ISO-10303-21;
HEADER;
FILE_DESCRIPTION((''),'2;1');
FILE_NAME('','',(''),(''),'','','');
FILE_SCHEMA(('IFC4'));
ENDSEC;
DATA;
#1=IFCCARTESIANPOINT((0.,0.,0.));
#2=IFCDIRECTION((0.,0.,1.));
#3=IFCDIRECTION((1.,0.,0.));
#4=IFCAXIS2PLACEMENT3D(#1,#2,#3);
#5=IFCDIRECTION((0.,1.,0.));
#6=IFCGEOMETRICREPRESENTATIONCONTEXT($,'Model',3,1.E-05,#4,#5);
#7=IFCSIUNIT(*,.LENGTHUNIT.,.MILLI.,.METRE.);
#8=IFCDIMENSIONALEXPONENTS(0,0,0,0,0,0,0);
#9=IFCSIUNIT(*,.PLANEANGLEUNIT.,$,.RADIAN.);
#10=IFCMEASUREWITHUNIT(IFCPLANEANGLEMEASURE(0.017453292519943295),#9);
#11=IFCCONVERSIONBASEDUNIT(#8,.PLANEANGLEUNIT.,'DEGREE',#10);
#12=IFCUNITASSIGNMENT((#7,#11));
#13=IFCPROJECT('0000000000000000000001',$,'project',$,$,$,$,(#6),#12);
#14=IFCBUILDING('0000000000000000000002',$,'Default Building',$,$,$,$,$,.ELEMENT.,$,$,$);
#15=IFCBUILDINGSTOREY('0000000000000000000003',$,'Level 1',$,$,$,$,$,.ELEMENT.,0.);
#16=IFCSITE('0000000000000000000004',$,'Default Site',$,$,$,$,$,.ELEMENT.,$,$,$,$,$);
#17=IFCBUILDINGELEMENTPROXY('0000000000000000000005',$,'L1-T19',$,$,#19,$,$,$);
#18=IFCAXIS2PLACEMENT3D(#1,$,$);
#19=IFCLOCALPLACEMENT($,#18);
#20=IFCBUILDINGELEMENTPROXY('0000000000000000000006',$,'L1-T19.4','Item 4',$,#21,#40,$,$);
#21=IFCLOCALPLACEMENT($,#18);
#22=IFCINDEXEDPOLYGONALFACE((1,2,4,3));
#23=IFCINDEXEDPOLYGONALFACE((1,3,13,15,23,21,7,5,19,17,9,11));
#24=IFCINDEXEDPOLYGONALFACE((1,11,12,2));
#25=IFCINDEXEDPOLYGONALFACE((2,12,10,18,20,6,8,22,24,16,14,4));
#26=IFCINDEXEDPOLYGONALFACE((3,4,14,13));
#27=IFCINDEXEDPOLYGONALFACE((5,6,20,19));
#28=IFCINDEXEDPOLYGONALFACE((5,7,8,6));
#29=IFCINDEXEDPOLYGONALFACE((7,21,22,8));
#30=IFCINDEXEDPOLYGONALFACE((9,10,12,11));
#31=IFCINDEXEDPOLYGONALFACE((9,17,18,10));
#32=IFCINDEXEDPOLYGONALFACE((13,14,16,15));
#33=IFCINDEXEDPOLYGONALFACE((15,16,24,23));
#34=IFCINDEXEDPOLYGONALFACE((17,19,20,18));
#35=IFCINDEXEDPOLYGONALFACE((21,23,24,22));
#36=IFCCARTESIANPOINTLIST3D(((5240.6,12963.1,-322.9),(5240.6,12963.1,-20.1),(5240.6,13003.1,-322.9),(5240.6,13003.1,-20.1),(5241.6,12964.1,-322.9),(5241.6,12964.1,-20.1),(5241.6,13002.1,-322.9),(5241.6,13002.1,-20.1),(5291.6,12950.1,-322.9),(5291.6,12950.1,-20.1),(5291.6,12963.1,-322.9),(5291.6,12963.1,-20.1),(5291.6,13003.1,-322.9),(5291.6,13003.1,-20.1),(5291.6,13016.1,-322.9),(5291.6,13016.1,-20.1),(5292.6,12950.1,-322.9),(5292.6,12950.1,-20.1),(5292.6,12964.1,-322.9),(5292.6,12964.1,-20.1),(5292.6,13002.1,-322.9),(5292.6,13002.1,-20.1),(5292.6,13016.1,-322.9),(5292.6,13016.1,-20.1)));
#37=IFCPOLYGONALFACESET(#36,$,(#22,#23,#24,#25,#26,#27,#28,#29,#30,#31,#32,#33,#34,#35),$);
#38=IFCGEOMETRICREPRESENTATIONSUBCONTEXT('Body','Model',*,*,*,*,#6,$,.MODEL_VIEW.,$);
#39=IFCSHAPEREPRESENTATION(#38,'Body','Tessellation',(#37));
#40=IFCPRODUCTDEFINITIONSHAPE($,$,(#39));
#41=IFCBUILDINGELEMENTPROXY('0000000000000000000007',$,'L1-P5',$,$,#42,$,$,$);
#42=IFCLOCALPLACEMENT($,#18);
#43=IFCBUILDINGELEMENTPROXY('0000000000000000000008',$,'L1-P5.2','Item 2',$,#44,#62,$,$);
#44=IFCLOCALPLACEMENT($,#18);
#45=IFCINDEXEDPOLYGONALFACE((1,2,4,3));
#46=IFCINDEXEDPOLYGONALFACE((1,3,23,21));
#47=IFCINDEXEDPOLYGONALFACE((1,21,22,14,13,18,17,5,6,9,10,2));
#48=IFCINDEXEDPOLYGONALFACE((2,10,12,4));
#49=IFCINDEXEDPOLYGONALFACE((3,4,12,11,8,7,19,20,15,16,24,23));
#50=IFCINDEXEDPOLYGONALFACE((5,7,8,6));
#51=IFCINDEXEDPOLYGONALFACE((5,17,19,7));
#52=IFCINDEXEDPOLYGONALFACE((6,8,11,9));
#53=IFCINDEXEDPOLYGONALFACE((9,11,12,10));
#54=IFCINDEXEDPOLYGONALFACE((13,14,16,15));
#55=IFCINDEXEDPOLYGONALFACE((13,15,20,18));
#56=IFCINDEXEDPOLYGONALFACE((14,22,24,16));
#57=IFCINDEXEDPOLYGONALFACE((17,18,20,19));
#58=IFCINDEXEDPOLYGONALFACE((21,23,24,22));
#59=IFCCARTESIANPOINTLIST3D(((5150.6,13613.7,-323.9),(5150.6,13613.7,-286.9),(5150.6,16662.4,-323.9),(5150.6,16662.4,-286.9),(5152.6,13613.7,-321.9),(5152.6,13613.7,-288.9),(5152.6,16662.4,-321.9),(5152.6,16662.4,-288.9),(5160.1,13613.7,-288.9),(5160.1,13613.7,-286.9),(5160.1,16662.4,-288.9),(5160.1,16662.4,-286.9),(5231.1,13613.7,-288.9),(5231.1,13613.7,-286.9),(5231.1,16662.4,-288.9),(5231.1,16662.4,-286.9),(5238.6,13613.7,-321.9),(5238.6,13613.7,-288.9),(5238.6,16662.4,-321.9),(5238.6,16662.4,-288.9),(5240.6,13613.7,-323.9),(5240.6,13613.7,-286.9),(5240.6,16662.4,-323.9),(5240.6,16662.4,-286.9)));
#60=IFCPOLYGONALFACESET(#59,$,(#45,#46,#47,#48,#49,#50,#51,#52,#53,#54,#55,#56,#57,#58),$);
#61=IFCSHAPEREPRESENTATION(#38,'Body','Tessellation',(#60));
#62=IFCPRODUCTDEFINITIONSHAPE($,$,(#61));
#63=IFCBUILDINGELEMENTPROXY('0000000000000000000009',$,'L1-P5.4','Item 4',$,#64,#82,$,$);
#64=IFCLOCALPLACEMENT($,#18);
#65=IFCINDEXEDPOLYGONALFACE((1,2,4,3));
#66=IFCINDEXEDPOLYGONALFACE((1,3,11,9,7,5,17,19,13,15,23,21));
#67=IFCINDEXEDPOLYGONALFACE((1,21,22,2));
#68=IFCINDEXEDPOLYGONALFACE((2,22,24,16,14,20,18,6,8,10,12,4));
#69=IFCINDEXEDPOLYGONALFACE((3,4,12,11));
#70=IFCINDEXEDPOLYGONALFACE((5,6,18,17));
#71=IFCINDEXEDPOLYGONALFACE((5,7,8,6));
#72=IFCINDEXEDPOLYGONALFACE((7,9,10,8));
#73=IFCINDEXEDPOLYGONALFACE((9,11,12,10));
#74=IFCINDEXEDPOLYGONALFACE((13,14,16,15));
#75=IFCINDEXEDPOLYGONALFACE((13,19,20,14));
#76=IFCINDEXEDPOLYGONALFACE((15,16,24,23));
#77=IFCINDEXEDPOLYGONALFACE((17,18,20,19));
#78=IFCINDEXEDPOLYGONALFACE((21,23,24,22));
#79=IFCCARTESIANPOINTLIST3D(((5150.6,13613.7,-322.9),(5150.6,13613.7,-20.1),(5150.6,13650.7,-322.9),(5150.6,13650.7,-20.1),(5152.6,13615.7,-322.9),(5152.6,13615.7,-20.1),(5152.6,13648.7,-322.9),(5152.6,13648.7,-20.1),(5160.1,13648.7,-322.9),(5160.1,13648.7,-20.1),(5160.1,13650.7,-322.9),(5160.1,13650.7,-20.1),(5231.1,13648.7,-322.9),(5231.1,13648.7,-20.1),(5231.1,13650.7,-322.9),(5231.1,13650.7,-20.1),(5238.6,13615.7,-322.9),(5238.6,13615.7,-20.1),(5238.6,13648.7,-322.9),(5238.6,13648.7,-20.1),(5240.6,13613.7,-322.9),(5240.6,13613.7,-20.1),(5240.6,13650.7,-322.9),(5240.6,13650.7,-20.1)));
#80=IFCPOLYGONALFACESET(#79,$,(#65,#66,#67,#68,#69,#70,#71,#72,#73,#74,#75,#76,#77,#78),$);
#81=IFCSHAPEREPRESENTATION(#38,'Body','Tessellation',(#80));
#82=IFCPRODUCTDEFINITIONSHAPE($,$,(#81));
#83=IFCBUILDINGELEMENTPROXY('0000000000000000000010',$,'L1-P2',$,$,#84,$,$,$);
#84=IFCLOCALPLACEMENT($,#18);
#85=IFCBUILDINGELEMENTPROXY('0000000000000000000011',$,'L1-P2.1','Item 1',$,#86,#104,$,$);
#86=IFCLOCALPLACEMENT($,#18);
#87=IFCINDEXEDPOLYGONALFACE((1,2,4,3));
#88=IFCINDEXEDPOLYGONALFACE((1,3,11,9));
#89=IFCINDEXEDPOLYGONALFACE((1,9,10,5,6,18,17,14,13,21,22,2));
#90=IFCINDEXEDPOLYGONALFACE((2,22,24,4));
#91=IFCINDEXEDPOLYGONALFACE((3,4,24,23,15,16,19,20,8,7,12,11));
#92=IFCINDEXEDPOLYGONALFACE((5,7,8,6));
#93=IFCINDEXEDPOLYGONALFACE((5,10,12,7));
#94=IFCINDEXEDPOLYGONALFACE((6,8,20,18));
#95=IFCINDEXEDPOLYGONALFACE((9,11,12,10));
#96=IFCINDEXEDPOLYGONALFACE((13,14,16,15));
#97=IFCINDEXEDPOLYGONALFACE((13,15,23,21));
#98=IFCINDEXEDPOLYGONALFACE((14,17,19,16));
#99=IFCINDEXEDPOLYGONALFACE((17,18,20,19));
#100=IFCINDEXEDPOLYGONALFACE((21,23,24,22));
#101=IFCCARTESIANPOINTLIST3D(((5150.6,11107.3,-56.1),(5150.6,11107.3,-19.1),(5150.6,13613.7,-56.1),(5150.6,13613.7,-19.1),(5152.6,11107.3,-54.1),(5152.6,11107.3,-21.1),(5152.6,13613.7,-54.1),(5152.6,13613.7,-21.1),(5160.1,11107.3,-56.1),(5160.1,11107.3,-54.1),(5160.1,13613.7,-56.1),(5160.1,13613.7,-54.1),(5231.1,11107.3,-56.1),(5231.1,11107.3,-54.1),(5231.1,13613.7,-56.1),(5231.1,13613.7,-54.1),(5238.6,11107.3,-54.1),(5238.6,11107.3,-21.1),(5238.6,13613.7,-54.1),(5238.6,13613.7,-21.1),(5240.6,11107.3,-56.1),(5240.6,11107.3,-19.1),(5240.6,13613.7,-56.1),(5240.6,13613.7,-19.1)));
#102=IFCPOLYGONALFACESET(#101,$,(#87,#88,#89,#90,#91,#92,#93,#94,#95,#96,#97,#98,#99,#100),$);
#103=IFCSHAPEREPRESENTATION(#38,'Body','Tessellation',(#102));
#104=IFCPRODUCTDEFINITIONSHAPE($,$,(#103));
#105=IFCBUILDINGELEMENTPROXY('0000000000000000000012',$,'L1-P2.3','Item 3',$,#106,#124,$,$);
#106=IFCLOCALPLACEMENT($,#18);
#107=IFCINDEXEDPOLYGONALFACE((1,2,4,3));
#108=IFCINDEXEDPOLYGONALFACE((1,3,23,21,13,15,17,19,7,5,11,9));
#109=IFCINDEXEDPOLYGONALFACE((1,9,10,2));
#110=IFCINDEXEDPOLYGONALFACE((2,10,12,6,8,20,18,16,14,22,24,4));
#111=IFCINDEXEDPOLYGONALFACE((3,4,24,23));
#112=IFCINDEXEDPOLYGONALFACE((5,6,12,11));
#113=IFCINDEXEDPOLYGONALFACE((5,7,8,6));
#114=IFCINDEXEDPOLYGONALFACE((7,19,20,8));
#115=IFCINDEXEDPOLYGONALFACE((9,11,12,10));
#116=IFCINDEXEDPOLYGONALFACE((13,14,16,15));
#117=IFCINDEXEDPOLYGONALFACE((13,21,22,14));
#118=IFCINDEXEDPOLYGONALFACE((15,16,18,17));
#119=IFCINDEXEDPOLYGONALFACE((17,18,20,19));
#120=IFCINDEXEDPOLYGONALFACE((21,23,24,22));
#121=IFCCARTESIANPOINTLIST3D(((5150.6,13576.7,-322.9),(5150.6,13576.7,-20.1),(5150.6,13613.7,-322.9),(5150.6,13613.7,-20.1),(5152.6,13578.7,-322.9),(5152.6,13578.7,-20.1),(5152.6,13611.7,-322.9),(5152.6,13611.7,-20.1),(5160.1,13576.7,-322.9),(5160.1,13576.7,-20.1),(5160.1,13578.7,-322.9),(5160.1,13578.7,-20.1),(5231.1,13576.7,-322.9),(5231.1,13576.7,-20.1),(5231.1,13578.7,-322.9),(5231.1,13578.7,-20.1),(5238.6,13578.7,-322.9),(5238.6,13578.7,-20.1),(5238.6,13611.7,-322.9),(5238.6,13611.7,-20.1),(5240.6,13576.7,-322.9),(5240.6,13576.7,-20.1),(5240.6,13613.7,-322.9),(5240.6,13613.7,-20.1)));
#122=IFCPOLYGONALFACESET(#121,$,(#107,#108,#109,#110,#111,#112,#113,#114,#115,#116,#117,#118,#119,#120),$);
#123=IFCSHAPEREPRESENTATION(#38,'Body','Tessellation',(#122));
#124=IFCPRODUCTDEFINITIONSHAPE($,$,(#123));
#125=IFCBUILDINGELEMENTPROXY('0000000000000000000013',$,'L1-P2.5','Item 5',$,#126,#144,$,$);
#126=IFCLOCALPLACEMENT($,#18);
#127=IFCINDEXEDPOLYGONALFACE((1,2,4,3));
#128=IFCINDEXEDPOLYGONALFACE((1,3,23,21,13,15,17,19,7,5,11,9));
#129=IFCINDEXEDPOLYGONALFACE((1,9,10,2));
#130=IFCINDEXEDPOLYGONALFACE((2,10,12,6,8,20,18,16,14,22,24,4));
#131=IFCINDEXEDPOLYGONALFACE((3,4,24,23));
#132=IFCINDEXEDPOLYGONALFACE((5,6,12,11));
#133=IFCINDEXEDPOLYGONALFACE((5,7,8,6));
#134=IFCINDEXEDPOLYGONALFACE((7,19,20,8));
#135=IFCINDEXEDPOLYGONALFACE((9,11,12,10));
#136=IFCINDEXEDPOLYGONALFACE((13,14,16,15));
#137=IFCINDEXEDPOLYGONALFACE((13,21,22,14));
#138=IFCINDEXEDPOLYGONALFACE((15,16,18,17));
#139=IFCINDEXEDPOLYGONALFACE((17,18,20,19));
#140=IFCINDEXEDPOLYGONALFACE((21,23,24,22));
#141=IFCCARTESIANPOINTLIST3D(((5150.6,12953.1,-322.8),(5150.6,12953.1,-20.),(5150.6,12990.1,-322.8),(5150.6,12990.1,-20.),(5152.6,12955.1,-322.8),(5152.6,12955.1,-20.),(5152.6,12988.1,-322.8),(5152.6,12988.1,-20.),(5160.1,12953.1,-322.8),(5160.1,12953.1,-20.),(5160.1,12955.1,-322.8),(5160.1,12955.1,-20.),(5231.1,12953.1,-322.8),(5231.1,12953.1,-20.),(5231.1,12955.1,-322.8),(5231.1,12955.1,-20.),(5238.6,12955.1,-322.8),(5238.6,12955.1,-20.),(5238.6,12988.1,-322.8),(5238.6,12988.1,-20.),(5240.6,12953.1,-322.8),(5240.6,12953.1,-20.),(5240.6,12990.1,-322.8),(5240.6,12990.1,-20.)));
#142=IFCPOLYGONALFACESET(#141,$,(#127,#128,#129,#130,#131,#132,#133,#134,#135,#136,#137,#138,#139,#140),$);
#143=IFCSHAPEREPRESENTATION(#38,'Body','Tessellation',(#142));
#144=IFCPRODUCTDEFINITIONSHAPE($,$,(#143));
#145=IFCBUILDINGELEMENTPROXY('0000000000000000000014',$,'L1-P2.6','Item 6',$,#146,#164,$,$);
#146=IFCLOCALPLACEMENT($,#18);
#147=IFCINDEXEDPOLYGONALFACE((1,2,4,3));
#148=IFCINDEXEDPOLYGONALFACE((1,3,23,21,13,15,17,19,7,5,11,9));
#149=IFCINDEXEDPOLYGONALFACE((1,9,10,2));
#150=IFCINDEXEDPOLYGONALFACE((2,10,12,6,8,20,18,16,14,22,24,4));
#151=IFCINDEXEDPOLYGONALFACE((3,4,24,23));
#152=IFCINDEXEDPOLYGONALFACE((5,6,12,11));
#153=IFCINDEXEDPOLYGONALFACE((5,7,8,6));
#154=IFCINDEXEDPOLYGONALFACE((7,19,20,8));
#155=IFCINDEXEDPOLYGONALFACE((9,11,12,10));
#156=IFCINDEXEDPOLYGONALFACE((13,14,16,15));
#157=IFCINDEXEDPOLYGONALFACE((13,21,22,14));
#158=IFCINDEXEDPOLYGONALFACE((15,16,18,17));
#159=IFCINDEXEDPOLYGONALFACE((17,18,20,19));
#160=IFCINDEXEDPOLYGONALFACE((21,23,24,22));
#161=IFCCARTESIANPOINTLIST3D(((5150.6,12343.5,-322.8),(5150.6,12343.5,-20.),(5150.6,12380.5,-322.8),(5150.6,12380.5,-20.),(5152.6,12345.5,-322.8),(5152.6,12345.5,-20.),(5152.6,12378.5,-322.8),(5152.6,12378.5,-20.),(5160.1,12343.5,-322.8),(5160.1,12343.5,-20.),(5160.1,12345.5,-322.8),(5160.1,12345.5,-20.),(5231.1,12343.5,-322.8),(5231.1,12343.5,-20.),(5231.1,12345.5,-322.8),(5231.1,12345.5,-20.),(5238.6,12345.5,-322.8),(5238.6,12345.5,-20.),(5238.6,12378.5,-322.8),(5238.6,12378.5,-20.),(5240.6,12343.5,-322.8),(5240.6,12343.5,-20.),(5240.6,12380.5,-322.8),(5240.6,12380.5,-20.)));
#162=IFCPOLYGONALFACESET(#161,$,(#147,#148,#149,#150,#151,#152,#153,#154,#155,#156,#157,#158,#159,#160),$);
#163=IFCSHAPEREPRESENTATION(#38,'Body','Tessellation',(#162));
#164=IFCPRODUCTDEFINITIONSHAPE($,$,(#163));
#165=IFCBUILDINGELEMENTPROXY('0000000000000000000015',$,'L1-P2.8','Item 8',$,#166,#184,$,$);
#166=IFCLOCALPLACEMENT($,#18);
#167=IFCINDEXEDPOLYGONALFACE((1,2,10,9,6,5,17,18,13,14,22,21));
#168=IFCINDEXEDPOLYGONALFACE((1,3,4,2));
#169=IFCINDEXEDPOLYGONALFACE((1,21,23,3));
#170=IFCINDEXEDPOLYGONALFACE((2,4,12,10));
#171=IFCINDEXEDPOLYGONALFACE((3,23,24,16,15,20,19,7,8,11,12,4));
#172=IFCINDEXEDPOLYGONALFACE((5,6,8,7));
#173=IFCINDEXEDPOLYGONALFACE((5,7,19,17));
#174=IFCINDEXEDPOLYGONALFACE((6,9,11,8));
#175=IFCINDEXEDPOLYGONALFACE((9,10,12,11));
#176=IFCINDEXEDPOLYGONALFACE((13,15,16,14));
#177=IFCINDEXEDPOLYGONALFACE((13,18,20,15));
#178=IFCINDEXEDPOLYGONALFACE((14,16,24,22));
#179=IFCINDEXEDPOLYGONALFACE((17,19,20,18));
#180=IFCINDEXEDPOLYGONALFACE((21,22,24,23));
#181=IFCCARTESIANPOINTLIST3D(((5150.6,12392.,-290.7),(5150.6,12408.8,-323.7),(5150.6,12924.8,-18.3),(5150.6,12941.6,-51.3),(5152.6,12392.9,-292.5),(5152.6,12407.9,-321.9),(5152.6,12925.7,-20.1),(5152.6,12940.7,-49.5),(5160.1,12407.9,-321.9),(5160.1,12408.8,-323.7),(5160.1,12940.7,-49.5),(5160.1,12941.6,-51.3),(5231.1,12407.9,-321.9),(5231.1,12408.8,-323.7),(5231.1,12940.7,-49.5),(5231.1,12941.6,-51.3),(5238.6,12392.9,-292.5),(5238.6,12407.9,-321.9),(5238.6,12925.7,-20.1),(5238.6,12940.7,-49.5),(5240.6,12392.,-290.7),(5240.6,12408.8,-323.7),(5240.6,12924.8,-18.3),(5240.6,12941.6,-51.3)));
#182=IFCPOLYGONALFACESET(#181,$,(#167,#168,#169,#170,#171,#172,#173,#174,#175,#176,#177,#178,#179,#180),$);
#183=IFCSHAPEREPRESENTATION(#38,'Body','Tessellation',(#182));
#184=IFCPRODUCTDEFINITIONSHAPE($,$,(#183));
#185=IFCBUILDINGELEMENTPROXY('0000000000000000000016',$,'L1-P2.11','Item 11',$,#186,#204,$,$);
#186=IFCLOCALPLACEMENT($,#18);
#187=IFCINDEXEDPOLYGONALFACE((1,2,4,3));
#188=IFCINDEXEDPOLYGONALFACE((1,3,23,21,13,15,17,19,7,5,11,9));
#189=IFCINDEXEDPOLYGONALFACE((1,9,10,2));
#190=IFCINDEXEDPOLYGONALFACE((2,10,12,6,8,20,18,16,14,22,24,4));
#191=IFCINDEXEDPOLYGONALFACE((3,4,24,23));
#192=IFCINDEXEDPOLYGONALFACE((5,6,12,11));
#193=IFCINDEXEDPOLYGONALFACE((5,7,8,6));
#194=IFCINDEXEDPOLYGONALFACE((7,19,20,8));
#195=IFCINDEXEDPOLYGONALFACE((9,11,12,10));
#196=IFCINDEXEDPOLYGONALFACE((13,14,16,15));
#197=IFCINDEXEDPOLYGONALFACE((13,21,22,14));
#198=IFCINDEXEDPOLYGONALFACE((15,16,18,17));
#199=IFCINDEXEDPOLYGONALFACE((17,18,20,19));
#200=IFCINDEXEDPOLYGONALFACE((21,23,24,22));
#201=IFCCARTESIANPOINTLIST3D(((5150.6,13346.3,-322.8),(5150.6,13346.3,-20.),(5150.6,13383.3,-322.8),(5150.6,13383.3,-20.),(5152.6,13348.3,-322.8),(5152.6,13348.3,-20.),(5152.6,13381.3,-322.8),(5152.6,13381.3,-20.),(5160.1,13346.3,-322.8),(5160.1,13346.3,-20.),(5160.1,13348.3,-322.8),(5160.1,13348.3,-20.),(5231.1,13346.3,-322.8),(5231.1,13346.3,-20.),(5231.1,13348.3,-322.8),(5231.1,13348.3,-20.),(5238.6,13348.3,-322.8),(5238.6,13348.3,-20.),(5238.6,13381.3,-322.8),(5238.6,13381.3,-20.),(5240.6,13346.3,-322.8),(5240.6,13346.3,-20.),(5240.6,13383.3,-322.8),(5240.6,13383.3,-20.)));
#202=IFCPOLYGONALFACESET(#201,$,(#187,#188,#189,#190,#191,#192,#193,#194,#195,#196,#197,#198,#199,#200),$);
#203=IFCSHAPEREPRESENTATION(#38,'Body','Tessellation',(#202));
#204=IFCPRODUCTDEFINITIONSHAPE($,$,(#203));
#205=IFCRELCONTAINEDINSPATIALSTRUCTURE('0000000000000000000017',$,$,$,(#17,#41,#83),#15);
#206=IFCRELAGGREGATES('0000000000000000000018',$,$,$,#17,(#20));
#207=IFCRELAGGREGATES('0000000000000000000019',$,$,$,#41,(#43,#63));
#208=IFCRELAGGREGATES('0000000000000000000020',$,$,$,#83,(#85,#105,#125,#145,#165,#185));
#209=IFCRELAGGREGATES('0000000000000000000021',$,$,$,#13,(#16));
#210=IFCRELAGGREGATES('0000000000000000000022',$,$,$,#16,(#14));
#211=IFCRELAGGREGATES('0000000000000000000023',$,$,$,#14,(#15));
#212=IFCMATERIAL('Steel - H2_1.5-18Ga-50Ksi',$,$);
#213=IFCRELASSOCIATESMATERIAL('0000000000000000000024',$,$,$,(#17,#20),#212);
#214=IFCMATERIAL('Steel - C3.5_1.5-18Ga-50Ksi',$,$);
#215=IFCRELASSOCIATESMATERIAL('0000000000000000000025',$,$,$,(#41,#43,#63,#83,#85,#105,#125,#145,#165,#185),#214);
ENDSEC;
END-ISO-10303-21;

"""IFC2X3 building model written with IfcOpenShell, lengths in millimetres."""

from ifc_helpers import new_model, entity, si_unit, converted_unit, direction, frame, origin, origin_with_axes, origin_2d_with_axis, place, context, subcontext, project, spatial, polyline, c_section, outline, extrude, material, element, aggregate, save


model = new_model("IFC2X3")

# Units and contexts
model_context = context("Model", 3, precision=1e-05, world=origin_with_axes(), true_north=direction((0.0, 1.0, 0.0)))
body_context = subcontext(model_context, "Body", "Model", "MODEL_VIEW")
ifc_project = project(units=[si_unit("LENGTHUNIT", "METRE", prefix="MILLI"), converted_unit("PLANEANGLEUNIT", "DEGREE", entity("IfcPlaneAngleMeasure", 0.017453292519943295), si_unit("PLANEANGLEUNIT", "RADIAN"), dimensions=[0, 0, 0, 0, 0, 0, 0])], contexts=[model_context])

# Site, building, storey
site = spatial("IfcSite", under=ifc_project, Name="Default Site", CompositionType="ELEMENT")
building = spatial("IfcBuilding", under=site, Name="Default Building", CompositionType="ELEMENT")
storey = spatial("IfcBuildingStorey", under=building, Name="Level 1", CompositionType="ELEMENT", Elevation=0.0)

# Shared definitions
ifc_material_1 = material(Name="Steel - C3.5_1.5-18Ga-50Ksi")

# Building element proxies
ifc_material_2 = material(Name="Steel - H2_1.5-18Ga-50Ksi")
proxy_1 = element("IfcBuildingElementProxy", 1, inside=storey, material=ifc_material_2, Name="L1-T19")
proxy_2_placement = place(None, frame((5292.6, 12950.1, -322.9), z_axis=(0.0, 0.0, 1.0), x_axis=(0.0, 40.0, 0.0)))
proxy_2 = element("IfcBuildingElementProxy", 2, at=proxy_2_placement, material=ifc_material_2, Name="L1-T19.4", Description="Item 4", context=body_context, shape_type="SweptSolid", body=[
    extrude(outline(polyline([(0.0, 0.0), (14.0, 0.0), (14.0, 51.0), (52.0, 51.0), (52.0, 0.0), (66.0, 0.0), (66.0, 1.0), (53.0, 1.0), (53.0, 52.0), (13.0, 52.0), (13.0, 1.0), (0.0, 1.0), (0.0, 0.0)])), origin(), (0.0, 0.0, 1.0), 302.8),
])
aggregate(proxy_1, [proxy_2])
proxy_3 = element("IfcBuildingElementProxy", 3, inside=storey, material=ifc_material_1, Name="L1-P5")
proxy_4_placement = place(None, frame((5195.6, 13613.7, -305.4), z_axis=(0.0, 1.0, 0.0), x_axis=(0.0, 0.0, 37.0)))
proxy_4 = element("IfcBuildingElementProxy", 4, at=proxy_4_placement, material=ifc_material_1, Name="L1-P5.2", Description="Item 2", context=body_context, shape_type="SweptSolid", body=[
    extrude(c_section(Depth=90.0, Width=37.0, WallThickness=2.0, Girth=9.5, at=origin_2d_with_axis()), origin(), (0.0, 0.0, 1.0), 3048.7),
])
proxy_5_placement = place(None, frame((5195.6, 13632.2, -20.1), z_axis=(0.0, 0.0, -1.0), x_axis=(0.0, 37.0, 0.0)))
proxy_5 = element("IfcBuildingElementProxy", 5, at=proxy_5_placement, material=ifc_material_1, Name="L1-P5.4", Description="Item 4", context=body_context, shape_type="SweptSolid", body=[
    extrude(c_section(Depth=90.0, Width=37.0, WallThickness=2.0, Girth=9.5, at=origin_2d_with_axis()), origin(), (0.0, 0.0, 1.0), 302.8),
])
aggregate(proxy_3, [proxy_4, proxy_5])
proxy_6 = element("IfcBuildingElementProxy", 6, inside=storey, material=ifc_material_1, Name="L1-P2")
proxy_7_placement = place(None, frame((5195.6, 13613.7, -37.6), z_axis=(0.0, -1.0, 0.0), x_axis=(0.0, 0.0, -37.0)))
proxy_7 = element("IfcBuildingElementProxy", 7, at=proxy_7_placement, material=ifc_material_1, Name="L1-P2.1", Description="Item 1", context=body_context, shape_type="SweptSolid", body=[
    extrude(c_section(Depth=90.0, Width=37.0, WallThickness=2.0, Girth=9.5, at=origin_2d_with_axis()), origin(), (0.0, 0.0, 1.0), 2506.4),
])
proxy_8_placement = place(None, frame((5195.6, 13595.2, -322.9), z_axis=(0.0, 0.0, 1.0), x_axis=(0.0, -37.0, 0.0)))
proxy_8 = element("IfcBuildingElementProxy", 8, at=proxy_8_placement, material=ifc_material_1, Name="L1-P2.3", Description="Item 3", context=body_context, shape_type="SweptSolid", body=[
    extrude(c_section(Depth=90.0, Width=37.0, WallThickness=2.0, Girth=9.5, at=origin_2d_with_axis()), origin(), (0.0, 0.0, 1.0), 302.8),
])
proxy_9_placement = place(None, frame((5195.6, 12971.6, -322.8), z_axis=(0.0, 0.0, 1.0), x_axis=(0.0, -37.0, 0.0)))
proxy_9 = element("IfcBuildingElementProxy", 9, at=proxy_9_placement, material=ifc_material_1, Name="L1-P2.5", Description="Item 5", context=body_context, shape_type="SweptSolid", body=[
    extrude(c_section(Depth=90.0, Width=37.0, WallThickness=2.0, Girth=9.5, at=origin_2d_with_axis()), origin(), (0.0, 0.0, 1.0), 302.8),
])
proxy_10_placement = place(None, frame((5195.6, 12362.0, -322.8), z_axis=(0.0, 0.0, 1.0), x_axis=(0.0, -37.0, 0.0)))
proxy_10 = element("IfcBuildingElementProxy", 10, at=proxy_10_placement, material=ifc_material_1, Name="L1-P2.6", Description="Item 6", context=body_context, shape_type="SweptSolid", body=[
    extrude(c_section(Depth=90.0, Width=37.0, WallThickness=2.0, Girth=9.5, at=origin_2d_with_axis()), origin(), (0.0, 0.0, 1.0), 302.8),
])
proxy_11_placement = place(None, frame((5195.6, 12933.2, -34.8), z_axis=(0.0, -0.89, -0.455), x_axis=(0.0, 16.852, -32.94)))
proxy_11 = element("IfcBuildingElementProxy", 11, at=proxy_11_placement, material=ifc_material_1, Name="L1-P2.8", Description="Item 8", context=body_context, shape_type="SweptSolid", body=[
    extrude(c_section(Depth=90.0, Width=37.0, WallThickness=2.0, Girth=9.5, at=origin_2d_with_axis()), origin(), (0.0, 0.0, 1.0), 598.4),
])
proxy_12_placement = place(None, frame((5195.6, 13364.8, -322.8), z_axis=(0.0, 0.0, 1.0), x_axis=(0.0, -37.0, 0.0)))
proxy_12 = element("IfcBuildingElementProxy", 12, at=proxy_12_placement, material=ifc_material_1, Name="L1-P2.11", Description="Item 11", context=body_context, shape_type="SweptSolid", body=[
    extrude(c_section(Depth=90.0, Width=37.0, WallThickness=2.0, Girth=9.5, at=origin_2d_with_axis()), origin(), (0.0, 0.0, 1.0), 302.8),
])
aggregate(proxy_6, [proxy_7, proxy_8, proxy_9, proxy_10, proxy_11, proxy_12])

save(model, "model.ifc")
